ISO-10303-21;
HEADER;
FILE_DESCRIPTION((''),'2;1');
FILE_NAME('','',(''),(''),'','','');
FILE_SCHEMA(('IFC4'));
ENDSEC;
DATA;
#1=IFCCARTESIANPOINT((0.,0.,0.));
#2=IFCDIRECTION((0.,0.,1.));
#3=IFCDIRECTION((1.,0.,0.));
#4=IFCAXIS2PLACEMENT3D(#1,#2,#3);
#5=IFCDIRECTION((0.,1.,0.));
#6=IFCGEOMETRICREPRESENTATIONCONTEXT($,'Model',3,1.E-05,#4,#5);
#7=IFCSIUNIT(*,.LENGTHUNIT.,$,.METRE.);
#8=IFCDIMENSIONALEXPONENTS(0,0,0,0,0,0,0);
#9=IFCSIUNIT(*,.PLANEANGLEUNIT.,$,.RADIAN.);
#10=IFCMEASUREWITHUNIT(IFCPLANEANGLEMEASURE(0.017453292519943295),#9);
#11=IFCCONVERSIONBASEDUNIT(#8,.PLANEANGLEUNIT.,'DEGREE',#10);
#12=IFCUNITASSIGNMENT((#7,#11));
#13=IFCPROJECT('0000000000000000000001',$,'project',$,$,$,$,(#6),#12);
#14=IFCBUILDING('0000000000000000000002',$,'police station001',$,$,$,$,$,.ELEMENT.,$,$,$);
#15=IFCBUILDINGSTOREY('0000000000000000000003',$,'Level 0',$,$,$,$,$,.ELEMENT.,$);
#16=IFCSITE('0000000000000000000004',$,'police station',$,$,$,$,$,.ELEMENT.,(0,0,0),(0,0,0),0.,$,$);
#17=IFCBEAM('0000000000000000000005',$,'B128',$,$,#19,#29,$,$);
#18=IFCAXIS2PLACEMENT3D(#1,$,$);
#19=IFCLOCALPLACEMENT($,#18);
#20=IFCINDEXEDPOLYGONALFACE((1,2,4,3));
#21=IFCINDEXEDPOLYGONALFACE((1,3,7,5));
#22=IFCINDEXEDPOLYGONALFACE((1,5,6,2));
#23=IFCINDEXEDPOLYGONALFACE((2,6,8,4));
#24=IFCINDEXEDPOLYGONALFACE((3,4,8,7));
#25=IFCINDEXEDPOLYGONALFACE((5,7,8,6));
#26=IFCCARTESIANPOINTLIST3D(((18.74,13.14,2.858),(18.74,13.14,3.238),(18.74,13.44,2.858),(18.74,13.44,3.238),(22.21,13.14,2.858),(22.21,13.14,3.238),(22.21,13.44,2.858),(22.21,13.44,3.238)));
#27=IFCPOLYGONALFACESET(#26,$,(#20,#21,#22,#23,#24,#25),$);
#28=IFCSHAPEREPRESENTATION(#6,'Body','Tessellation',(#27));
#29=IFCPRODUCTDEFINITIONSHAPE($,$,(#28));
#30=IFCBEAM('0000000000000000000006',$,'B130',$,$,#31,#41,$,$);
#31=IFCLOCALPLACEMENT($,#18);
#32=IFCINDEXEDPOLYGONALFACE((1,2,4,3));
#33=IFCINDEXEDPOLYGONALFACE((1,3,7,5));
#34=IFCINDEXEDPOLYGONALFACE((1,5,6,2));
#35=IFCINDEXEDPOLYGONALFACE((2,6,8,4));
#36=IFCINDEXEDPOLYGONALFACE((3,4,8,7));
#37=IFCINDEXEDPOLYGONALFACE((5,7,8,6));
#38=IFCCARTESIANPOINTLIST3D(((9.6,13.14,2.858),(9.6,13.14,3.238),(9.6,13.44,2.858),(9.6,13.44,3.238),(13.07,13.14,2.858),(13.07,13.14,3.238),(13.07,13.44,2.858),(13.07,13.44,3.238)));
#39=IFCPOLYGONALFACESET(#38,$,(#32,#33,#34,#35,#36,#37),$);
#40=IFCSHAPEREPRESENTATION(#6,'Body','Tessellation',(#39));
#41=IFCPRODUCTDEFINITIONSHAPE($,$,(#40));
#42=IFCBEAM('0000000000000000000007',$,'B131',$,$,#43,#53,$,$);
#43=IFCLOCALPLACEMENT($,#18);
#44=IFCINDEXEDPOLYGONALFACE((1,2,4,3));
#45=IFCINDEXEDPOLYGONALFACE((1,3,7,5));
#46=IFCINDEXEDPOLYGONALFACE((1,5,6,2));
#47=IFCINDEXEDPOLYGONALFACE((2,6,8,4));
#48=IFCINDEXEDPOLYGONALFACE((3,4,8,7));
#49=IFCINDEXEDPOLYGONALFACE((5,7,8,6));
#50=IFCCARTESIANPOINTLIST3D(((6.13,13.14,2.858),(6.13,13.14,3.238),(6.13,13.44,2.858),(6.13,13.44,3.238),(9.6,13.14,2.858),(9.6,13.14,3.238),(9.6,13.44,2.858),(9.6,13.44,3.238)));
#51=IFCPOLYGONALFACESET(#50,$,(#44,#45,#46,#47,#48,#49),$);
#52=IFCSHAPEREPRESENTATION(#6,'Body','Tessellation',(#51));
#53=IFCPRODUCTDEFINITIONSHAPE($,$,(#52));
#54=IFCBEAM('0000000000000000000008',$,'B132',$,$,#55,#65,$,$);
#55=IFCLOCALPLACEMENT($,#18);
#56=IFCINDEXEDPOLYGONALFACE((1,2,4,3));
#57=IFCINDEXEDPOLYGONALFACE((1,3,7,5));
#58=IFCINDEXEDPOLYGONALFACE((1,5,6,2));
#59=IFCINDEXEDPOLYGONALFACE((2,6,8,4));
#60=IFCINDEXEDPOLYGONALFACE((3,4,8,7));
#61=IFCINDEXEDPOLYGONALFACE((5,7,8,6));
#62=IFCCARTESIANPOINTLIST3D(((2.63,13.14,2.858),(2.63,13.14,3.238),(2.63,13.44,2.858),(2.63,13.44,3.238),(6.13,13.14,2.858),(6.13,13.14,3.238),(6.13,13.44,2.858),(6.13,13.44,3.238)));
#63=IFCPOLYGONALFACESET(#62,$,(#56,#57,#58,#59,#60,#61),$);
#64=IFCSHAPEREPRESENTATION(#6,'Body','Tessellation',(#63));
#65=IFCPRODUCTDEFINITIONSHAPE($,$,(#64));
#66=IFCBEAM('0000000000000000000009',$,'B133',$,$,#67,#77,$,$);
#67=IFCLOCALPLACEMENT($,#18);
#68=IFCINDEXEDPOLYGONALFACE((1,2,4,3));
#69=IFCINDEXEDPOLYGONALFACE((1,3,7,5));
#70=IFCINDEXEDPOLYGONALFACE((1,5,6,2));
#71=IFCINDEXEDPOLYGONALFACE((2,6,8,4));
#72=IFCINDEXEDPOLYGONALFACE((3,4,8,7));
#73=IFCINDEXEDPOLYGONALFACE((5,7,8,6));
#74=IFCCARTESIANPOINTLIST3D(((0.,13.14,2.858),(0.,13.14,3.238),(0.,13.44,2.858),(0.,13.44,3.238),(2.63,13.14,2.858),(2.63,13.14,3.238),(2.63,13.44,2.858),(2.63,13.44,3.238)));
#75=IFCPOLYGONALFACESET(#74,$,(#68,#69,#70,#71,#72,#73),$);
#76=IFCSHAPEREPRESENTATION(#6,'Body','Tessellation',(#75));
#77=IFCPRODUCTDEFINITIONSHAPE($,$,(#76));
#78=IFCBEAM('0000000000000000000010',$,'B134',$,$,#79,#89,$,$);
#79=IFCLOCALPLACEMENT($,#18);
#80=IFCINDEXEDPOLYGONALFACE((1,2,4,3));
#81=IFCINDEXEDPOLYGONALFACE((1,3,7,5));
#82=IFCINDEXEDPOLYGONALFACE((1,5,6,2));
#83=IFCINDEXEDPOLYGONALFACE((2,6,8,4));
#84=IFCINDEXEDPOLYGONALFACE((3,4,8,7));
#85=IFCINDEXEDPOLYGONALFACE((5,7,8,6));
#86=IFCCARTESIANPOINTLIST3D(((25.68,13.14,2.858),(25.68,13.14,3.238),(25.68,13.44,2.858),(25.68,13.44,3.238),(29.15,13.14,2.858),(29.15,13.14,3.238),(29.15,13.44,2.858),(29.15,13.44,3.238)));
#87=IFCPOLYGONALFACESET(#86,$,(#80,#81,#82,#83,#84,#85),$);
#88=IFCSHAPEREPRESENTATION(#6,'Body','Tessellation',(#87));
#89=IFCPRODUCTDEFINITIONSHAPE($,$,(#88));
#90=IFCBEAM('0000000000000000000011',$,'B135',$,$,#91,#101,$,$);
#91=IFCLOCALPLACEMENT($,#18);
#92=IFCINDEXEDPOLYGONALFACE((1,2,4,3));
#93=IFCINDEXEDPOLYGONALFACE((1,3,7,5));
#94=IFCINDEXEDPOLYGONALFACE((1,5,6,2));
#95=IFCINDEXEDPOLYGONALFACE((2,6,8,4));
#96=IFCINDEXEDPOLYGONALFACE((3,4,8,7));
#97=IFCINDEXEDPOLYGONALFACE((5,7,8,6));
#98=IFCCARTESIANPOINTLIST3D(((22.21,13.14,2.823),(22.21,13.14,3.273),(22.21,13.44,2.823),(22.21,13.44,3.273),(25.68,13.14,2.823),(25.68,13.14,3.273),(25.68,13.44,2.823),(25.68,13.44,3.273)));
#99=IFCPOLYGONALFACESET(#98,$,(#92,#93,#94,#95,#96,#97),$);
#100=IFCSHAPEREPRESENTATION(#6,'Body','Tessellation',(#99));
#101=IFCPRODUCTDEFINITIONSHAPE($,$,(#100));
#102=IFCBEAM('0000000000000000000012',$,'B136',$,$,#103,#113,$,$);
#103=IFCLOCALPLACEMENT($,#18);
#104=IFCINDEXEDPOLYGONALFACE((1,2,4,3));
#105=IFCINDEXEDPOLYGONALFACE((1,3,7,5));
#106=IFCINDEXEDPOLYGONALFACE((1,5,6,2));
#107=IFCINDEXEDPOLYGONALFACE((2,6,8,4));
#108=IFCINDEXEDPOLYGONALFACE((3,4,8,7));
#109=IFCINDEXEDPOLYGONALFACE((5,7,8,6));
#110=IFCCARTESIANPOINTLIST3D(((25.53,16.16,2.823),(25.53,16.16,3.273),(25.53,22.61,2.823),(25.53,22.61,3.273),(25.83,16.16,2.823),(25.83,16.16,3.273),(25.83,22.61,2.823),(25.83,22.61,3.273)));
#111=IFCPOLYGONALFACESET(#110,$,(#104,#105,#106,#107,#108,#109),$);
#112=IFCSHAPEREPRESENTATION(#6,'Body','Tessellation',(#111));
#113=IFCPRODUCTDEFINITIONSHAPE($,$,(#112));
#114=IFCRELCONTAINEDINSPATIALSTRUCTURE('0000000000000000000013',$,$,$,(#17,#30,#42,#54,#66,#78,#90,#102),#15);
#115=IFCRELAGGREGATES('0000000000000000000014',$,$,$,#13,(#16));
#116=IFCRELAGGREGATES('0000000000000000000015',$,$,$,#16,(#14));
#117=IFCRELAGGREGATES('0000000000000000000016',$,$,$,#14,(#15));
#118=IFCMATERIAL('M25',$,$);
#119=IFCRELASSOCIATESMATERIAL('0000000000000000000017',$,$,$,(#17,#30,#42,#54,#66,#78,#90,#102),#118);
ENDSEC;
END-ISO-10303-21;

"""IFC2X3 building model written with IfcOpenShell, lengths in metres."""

from ifc_helpers import new_model, entity, si_unit, converted_unit, direction, frame, frame_2d, origin_with_axes, place, context, project, spatial, rectangle, extrude, material, element, save


model = new_model("IFC2X3")

# Units and contexts
model_context = context("Model", 3, precision=1e-05, world=origin_with_axes(), true_north=direction((0.0, 1.0, 0.0)))
ifc_project = project(units=[si_unit("LENGTHUNIT", "METRE"), converted_unit("PLANEANGLEUNIT", "DEGREE", entity("IfcPlaneAngleMeasure", 0.017453292519943295), si_unit("PLANEANGLEUNIT", "RADIAN"), dimensions=[0, 0, 0, 0, 0, 0, 0])], contexts=[model_context])

# Site, building, storey
site = spatial("IfcSite", under=ifc_project, Name="police station", CompositionType="ELEMENT", RefLatitude=(0, 0, 0), RefLongitude=(0, 0, 0), RefElevation=0.0)
building = spatial("IfcBuilding", under=site, Name="police station001", CompositionType="ELEMENT")
storey = spatial("IfcBuildingStorey", under=building, Name="Level 0", CompositionType="ELEMENT")

# Beams
ifc_material = material(Name="M25")
placement = place(None, origin_with_axes())
element("IfcBeam", 1, at=placement, inside=storey, material=ifc_material, Name="B128", context=model_context, shape_type="SweptSolid", body=[
    extrude(rectangle(XDim=0.3, YDim=0.38, at=frame_2d((0.0, 0.0), x_axis=(0.0, 1.0, 0.0))), frame((22.21, 13.29, 3.048), z_axis=(-1.0, 0.0, 0.0), x_axis=(0.0, 0.0, -1.0)), (0.0, 0.0, 1.0), 3.47),
])
element("IfcBeam", 2, at=placement, inside=storey, material=ifc_material, Name="B130", context=model_context, shape_type="SweptSolid", body=[
    extrude(rectangle(XDim=0.3, YDim=0.38, at=frame_2d((0.0, 0.0), x_axis=(0.0, 1.0, 0.0))), frame((13.07, 13.29, 3.048), z_axis=(-1.0, 0.0, 0.0), x_axis=(0.0, 0.0, -1.0)), (0.0, 0.0, 1.0), 3.47),
])
element("IfcBeam", 3, at=placement, inside=storey, material=ifc_material, Name="B131", context=model_context, shape_type="SweptSolid", body=[
    extrude(rectangle(XDim=0.3, YDim=0.38, at=frame_2d((0.0, 0.0), x_axis=(0.0, 1.0, 0.0))), frame((9.6, 13.29, 3.048), z_axis=(-1.0, 0.0, 0.0), x_axis=(0.0, 0.0, -1.0)), (0.0, 0.0, 1.0), 3.47),
])
element("IfcBeam", 4, at=placement, inside=storey, material=ifc_material, Name="B132", context=model_context, shape_type="SweptSolid", body=[
    extrude(rectangle(XDim=0.3, YDim=0.38, at=frame_2d((0.0, 0.0), x_axis=(0.0, 1.0, 0.0))), frame((2.63, 13.29, 3.048), z_axis=(1.0, 0.0, 0.0), x_axis=(0.0, 0.0, -1.0)), (0.0, 0.0, 1.0), 3.5),
])
element("IfcBeam", 5, at=placement, inside=storey, material=ifc_material, Name="B133", context=model_context, shape_type="SweptSolid", body=[
    extrude(rectangle(XDim=0.3, YDim=0.38, at=frame_2d((0.0, 0.0), x_axis=(0.0, 1.0, 0.0))), frame((0.0, 13.29, 3.048), z_axis=(1.0, 0.0, 0.0), x_axis=(0.0, 0.0, -1.0)), (0.0, 0.0, 1.0), 2.63),
])
element("IfcBeam", 6, at=placement, inside=storey, material=ifc_material, Name="B134", context=model_context, shape_type="SweptSolid", body=[
    extrude(rectangle(XDim=0.3, YDim=0.38, at=frame_2d((0.0, 0.0), x_axis=(0.0, 1.0, 0.0))), frame((29.15, 13.29, 3.048), z_axis=(-1.0, 0.0, 0.0), x_axis=(0.0, 0.0, -1.0)), (0.0, 0.0, 1.0), 3.47),
])
element("IfcBeam", 7, at=placement, inside=storey, material=ifc_material, Name="B135", context=model_context, shape_type="SweptSolid", body=[
    extrude(rectangle(XDim=0.3, YDim=0.45, at=frame_2d((0.0, 0.0), x_axis=(0.0, 1.0, 0.0))), frame((25.68, 13.29, 3.048), z_axis=(-1.0, 0.0, 0.0), x_axis=(0.0, 0.0, -1.0)), (0.0, 0.0, 1.0), 3.47),
])
element("IfcBeam", 8, at=placement, inside=storey, material=ifc_material, Name="B136", context=model_context, shape_type="SweptSolid", body=[
    extrude(rectangle(XDim=0.3, YDim=0.45, at=frame_2d((0.0, 0.0), x_axis=(0.0, 1.0, 0.0))), frame((25.68, 22.61, 3.048), z_axis=(0.0, -1.0, 0.0), x_axis=(0.0, 0.0, -1.0)), (0.0, 0.0, 1.0), 6.45),
])

save(model, "model.ifc")
